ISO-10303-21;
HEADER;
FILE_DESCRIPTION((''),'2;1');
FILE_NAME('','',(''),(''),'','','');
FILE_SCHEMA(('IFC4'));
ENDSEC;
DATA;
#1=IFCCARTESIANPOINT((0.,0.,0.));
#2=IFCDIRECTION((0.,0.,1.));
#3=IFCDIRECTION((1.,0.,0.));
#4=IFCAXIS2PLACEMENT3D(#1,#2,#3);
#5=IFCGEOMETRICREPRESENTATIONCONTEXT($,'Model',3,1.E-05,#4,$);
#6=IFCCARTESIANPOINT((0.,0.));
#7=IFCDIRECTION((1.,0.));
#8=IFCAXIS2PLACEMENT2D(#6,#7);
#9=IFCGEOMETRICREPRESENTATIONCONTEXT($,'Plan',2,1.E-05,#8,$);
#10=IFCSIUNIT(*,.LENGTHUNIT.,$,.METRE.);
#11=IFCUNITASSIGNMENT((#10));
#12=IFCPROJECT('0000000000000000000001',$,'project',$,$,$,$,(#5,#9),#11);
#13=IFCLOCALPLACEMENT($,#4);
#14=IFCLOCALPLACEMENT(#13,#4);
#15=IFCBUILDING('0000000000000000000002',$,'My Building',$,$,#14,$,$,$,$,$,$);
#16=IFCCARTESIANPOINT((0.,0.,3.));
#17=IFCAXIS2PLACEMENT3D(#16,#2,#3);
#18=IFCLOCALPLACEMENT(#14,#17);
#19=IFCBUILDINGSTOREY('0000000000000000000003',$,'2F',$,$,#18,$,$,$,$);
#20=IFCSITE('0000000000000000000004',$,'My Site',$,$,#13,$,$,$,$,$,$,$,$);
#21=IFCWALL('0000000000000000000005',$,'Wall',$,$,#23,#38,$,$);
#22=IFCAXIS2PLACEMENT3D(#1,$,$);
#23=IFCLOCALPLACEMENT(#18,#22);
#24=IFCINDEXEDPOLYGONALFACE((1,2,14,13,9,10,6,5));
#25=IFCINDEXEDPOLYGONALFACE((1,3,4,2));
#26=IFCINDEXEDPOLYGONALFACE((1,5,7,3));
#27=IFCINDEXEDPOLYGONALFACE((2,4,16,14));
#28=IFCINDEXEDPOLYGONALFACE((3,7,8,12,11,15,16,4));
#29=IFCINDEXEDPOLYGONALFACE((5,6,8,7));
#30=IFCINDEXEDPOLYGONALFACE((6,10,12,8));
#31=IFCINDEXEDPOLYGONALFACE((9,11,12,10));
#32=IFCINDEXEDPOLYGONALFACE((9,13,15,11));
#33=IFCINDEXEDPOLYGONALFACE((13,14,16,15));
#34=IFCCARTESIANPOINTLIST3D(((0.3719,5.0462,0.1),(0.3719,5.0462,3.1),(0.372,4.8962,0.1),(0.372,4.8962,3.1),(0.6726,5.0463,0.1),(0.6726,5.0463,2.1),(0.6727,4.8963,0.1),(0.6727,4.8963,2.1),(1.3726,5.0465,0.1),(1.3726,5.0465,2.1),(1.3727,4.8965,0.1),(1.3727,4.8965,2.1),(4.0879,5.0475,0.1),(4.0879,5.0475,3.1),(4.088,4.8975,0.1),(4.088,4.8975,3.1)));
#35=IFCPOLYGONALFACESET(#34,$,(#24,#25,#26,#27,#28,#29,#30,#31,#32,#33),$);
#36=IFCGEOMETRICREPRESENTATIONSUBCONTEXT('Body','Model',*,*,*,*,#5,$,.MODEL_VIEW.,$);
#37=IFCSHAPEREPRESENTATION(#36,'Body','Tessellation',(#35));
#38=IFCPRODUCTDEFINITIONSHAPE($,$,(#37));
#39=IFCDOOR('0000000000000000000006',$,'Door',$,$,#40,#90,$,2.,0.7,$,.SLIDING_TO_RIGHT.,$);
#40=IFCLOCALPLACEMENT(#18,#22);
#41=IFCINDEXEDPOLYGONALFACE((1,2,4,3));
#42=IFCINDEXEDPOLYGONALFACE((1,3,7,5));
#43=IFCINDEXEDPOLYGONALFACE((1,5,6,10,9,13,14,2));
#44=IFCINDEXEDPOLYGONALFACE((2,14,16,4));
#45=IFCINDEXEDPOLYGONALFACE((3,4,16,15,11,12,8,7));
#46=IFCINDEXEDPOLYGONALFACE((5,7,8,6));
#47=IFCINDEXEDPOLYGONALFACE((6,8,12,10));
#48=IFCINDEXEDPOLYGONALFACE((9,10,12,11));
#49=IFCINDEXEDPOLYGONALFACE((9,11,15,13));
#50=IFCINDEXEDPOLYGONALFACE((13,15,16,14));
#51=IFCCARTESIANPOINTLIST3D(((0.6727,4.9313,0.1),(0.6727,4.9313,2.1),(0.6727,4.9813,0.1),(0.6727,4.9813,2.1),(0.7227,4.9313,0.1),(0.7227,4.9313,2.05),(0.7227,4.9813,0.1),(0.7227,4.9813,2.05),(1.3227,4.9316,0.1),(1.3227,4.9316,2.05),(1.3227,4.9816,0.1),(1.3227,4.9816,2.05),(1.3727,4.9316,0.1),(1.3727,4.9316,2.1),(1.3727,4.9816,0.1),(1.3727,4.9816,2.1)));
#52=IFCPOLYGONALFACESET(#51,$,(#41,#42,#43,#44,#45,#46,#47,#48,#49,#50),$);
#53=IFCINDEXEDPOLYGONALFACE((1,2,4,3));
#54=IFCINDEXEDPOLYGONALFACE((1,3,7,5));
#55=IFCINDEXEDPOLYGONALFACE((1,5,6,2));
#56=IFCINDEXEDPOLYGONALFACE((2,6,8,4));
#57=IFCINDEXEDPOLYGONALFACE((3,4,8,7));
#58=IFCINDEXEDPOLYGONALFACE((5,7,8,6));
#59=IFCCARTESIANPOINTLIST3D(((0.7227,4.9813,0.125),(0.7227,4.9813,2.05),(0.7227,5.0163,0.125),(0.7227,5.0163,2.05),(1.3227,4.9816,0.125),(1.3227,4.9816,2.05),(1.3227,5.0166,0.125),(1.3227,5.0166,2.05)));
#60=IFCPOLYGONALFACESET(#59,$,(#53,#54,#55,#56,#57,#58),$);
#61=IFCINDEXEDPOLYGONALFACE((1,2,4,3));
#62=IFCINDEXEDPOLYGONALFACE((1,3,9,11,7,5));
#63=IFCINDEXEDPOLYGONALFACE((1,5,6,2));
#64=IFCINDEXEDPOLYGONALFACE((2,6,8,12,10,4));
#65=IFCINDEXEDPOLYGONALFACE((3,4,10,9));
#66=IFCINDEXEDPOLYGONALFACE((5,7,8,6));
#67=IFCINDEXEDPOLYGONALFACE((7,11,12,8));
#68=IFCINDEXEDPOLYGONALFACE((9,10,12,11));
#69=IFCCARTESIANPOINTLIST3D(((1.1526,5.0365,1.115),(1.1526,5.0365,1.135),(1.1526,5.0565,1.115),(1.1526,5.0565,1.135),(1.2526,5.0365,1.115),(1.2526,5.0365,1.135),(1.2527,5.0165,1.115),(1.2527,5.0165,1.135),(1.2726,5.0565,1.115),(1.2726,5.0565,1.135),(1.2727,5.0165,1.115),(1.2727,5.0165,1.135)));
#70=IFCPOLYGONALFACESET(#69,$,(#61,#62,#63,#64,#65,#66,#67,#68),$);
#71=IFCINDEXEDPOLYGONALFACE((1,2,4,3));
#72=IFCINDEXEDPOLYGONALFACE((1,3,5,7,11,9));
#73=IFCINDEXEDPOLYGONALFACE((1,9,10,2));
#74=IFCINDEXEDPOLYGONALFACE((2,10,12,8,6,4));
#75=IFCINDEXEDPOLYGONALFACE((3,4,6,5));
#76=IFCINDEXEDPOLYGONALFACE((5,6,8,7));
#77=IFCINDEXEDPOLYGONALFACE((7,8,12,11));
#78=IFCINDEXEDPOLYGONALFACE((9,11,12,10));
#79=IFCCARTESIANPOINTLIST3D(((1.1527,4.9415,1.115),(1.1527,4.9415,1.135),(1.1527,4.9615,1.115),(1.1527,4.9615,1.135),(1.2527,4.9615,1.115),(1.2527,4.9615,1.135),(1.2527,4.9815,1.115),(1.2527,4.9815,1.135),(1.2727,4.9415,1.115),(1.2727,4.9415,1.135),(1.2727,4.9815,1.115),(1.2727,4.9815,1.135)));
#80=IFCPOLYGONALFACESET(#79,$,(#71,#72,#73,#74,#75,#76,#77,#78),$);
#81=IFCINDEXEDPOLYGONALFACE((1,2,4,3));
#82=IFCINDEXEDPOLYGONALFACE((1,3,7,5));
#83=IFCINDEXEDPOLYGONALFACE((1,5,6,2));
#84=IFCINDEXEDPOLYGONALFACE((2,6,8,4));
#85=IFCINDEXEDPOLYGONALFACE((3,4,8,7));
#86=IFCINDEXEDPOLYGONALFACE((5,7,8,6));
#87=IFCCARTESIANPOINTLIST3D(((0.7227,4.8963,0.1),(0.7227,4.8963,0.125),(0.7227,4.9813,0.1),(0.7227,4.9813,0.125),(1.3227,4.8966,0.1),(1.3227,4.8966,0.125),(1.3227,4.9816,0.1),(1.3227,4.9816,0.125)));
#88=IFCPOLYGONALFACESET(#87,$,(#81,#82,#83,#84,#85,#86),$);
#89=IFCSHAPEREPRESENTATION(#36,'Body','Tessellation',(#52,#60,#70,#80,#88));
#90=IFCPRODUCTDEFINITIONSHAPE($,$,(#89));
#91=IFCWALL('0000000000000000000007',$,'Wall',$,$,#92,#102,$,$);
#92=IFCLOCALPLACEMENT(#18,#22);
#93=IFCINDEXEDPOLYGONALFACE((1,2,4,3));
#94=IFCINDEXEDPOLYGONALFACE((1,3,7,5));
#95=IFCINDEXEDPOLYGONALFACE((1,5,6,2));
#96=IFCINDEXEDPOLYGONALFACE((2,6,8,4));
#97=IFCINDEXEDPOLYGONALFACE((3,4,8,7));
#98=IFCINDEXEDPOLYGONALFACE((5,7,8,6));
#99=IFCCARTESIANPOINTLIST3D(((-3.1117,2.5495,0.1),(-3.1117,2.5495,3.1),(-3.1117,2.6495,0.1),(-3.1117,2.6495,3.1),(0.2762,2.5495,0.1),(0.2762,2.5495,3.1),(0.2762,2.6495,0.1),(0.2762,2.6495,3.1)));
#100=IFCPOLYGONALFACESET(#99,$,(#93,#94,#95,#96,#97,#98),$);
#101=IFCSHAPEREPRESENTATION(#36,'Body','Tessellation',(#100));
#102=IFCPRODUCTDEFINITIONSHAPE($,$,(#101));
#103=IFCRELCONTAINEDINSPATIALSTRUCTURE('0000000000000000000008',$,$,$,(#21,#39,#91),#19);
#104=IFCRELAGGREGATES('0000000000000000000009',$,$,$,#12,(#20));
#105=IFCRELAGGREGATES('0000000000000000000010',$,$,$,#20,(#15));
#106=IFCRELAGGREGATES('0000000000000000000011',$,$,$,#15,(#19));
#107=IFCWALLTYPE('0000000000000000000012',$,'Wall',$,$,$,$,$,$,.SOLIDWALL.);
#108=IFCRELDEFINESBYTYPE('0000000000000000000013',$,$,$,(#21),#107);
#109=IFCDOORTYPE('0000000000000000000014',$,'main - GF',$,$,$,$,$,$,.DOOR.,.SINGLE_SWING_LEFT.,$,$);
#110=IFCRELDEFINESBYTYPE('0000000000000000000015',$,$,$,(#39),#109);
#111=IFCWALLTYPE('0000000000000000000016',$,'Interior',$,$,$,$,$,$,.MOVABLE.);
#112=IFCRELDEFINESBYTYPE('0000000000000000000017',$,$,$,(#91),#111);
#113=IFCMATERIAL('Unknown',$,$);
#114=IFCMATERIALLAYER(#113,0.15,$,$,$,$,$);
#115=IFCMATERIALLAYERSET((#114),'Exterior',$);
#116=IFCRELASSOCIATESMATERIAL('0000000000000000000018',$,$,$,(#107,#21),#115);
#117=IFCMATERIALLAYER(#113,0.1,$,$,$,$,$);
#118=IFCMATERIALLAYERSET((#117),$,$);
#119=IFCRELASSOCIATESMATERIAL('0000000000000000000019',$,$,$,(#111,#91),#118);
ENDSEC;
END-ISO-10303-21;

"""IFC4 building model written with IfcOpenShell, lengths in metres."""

from ifc_helpers import new_model, entity, si_unit, frame, origin_with_axes, origin_2d_with_axis, place, context, subcontext, project, spatial, line, indexed_curve, outline, extrude, shape, source, transform, mapped, material, layer, layer_set, layer_usage, type_object, type_shapes, element, fill, save


model = new_model("IFC4")

# Units and contexts
model_context = context("Model", 3, precision=1e-05, world=origin_with_axes())
plan_context = context("Plan", 2, precision=1e-05, world=origin_2d_with_axis())
body_context_1 = subcontext(model_context, "Body", "Model", "MODEL_VIEW")
body_context_2 = subcontext(plan_context, "Body", "Plan", "PLAN_VIEW")
ifc_project = project(units=[si_unit("LENGTHUNIT", "METRE")], contexts=[model_context, plan_context])

# Site, building, storey
site_placement = place(None, origin_with_axes())
site = spatial("IfcSite", under=ifc_project, at=site_placement, Name="My Site")
building_placement = place(site_placement, origin_with_axes())
building = spatial("IfcBuilding", under=site, at=building_placement, Name="My Building")
storey_placement = place(building_placement, frame((0.0, 0.0, 3.0), z_axis=(0.0, 0.0, 1.0), x_axis=(1.0, 0.0, 0.0)))
storey = spatial("IfcBuildingStorey", under=building, at=storey_placement, Name="2F")

# Shared definitions
ifc_material = material(Name="Unknown")

# Shared definitions
ifc_layer_1 = layer(ifc_material, 0.15)
ifc_layer_set_1 = layer_set([ifc_layer_1], Name="Exterior")
wall_type_1 = type_object("IfcWallType", Name="Wall", PredefinedType="SOLIDWALL", material=ifc_layer_set_1)

# Wall, opening, door
ifc_layer_usage_1 = layer_usage(ifc_layer_set_1, "AXIS2", "POSITIVE", 0.0)
wall_1_placement = place(storey_placement, frame((0.372, 4.8962, 0.1), z_axis=(0.0, 0.0, 1.0), x_axis=(1.0, 0.000354, 0.0)))
wall_1 = element("IfcWall", 1, at=wall_1_placement, inside=storey, type_object=wall_type_1, material=ifc_layer_usage_1, Name="Wall", context=body_context_1, shape_type="SweptSolid", body=[
    extrude(outline(indexed_curve([(0.0, 0.0), (0.0, 0.15), (3.716, 0.15), (3.716, 0.0)], segments=[line(1, 2, 3, 4, 1)])), origin_with_axes(), (0.0, 0.0, 1.0), 3.0),
])
shared_shape_1 = source(origin_with_axes(), body_context_1, "Body", "SweptSolid", [
    extrude(outline(indexed_curve([(0.0, 0.0), (0.7, 0.0), (0.7, 2.0), (0.0, 2.0)], segments=[line(1, 2, 3, 4, 1)])), frame((0.0, -0.6, 0.0), z_axis=(0.0, -1.0, 0.0), x_axis=(1.0, 0.0, 0.0)), (0.0, 0.0, -1.0), 1.2),
])
opening_1_placement = place(wall_1_placement, frame((1.0007, 0.085, 0.0), z_axis=(0.0, 0.0, 1.0), x_axis=(-1.0, 0.0, 0.0)))
opening_1 = element("IfcOpeningElement", 2, at=opening_1_placement, cuts=wall_1, PredefinedType="OPENING", context=body_context_1, shape_type="MappedRepresentation", body=[
    mapped(shared_shape_1, transform((0.0, 0.0, 0.0), x_axis=(1.0, 0.0, 0.0), y_axis=(0.0, 1.0, 0.0), z_axis=(0.0, 0.0, 1.0), scale=1.0)),
])
door_type_1 = type_object("IfcDoorType", Name="main - GF", OperationType="SINGLE_SWING_LEFT", PredefinedType="DOOR")
shared_shape_2 = source(origin_with_axes(), body_context_1, "Body", "SweptSolid", [
    extrude(outline(indexed_curve([(0.0, 0.0), (0.0, 2.0), (0.7, 2.0), (0.7, 0.0), (0.65, 0.0), (0.65, 1.95), (0.05, 1.95), (0.05, 0.0)], segments=[line(1, 2, 3, 4, 5, 6, 7, 8, 1)])), frame((0.0, 0.0, 0.0), z_axis=(0.0, -1.0, 0.0), x_axis=(1.0, 0.0, 0.0)), (0.0, 0.0, -1.0), 0.05),
    extrude(outline(indexed_curve([(0.0, 0.0), (0.6, 0.0), (0.6, 0.035), (0.0, 0.035)], segments=[line(1, 2, 3, 4, 1)])), frame((0.05, -0.035, 0.025), z_axis=(0.0, 0.0, 1.0), x_axis=(1.0, 0.0, 0.0)), (0.0, 0.0, 1.0), 1.925),
    extrude(outline(indexed_curve([(0.0, 0.0), (0.0, -0.04), (0.12, -0.04), (0.12, -0.02), (0.02, -0.02), (0.02, 0.0)], segments=[line(1, 2, 3, 4, 5, 6, 1)])), frame((0.1, -0.035, 1.015), z_axis=(0.0, 0.0, 1.0), x_axis=(1.0, 0.0, 0.0)), (0.0, 0.0, 1.0), 0.02),
    extrude(outline(indexed_curve([(0.0, 0.0), (0.0, 0.04), (0.12, 0.04), (0.12, 0.02), (0.02, 0.02), (0.02, 0.0)], segments=[line(1, 2, 3, 4, 5, 6, 1)])), frame((0.1, 0.0, 1.015), z_axis=(0.0, 0.0, 1.0), x_axis=(1.0, 0.0, 0.0)), (0.0, 0.0, 1.0), 0.02),
    extrude(outline(indexed_curve([(0.0, 0.0), (0.6, 0.0), (0.6, 0.085), (0.0, 0.085)], segments=[line(1, 2, 3, 4, 1)])), frame((0.05, 0.0, 0.0), z_axis=(0.0, 0.0, 1.0), x_axis=(1.0, 0.0, 0.0)), (0.0, 0.0, 1.0), 0.025),
])
shared_shape_3 = source(origin_with_axes(), body_context_2, "Body", "Curve2D", [
    entity("IfcIndexedPolyCurve", entity("IfcCartesianPointList2D", [[0.0, 0.0], [0.05, 0.0], [0.05, 0.05], [0.0, 0.05]]), [entity("IfcLineIndex", [1, 2, 3, 4, 1])]),
    entity("IfcIndexedPolyCurve", entity("IfcCartesianPointList2D", [[0.7, 0.0], [0.65, 0.0], [0.65, 0.05], [0.7, 0.05]]), [entity("IfcLineIndex", [1, 2, 3, 4, 1])]),
    entity("IfcIndexedPolyCurve", entity("IfcCartesianPointList2D", [[0.95, -0.035], [0.35, -0.035], [0.35, 0.0], [0.95, 0.0]]), [entity("IfcLineIndex", [1, 2, 3, 4, 1])]),
])
type_shapes(door_type_1, [shared_shape_2, shared_shape_3])
door_1_placement = place(opening_1_placement, frame((0.0, 0.0, 0.0), z_axis=(0.0, 0.0, 1.0), x_axis=(1.0, 0.0, 0.0)))
door_1 = element("IfcDoor", 3, at=door_1_placement, inside=storey, type_object=door_type_1, Name="Door", OperationType="SLIDING_TO_RIGHT", OverallHeight=2.0, OverallWidth=0.7, shapes=[
    shape(body_context_1, "Body", "MappedRepresentation", [mapped(shared_shape_2, transform((0.0, 0.0, 0.0), x_axis=(1.0, 0.0, 0.0), y_axis=(0.0, 1.0, 0.0), z_axis=(0.0, 0.0, 1.0), scale=1.0))]),
    shape(body_context_2, "Body", "MappedRepresentation", [mapped(shared_shape_3, transform((0.0, 0.0, 0.0), x_axis=(1.0, 0.0, 0.0), y_axis=(0.0, 1.0, 0.0), z_axis=(0.0, 0.0, 1.0), scale=1.0))]),
])
fill(opening_1, door_1)

# Shared definitions
ifc_layer_2 = layer(ifc_material, 0.1)
ifc_layer_set_2 = layer_set([ifc_layer_2])
wall_type_2 = type_object("IfcWallType", Name="Interior", PredefinedType="MOVABLE", material=ifc_layer_set_2)

# Wall
ifc_layer_usage_2 = layer_usage(ifc_layer_set_2, "AXIS2", "POSITIVE", 0.0)
wall_2_placement = place(storey_placement, frame((-3.1117, 2.5495, 0.1), z_axis=(0.0, 0.0, 1.0), x_axis=(1.0, 0.000006, 0.0)))
element("IfcWall", 4, at=wall_2_placement, inside=storey, type_object=wall_type_2, material=ifc_layer_usage_2, Name="Wall", context=body_context_1, shape_type="SweptSolid", body=[
    extrude(outline(indexed_curve([(0.0, 0.0), (0.0, 0.1), (3.3879, 0.1), (3.3879, 0.0)], segments=[line(1, 2, 3, 4, 1)])), origin_with_axes(), (0.0, 0.0, 1.0), 3.0),
])

save(model, "model.ifc")
